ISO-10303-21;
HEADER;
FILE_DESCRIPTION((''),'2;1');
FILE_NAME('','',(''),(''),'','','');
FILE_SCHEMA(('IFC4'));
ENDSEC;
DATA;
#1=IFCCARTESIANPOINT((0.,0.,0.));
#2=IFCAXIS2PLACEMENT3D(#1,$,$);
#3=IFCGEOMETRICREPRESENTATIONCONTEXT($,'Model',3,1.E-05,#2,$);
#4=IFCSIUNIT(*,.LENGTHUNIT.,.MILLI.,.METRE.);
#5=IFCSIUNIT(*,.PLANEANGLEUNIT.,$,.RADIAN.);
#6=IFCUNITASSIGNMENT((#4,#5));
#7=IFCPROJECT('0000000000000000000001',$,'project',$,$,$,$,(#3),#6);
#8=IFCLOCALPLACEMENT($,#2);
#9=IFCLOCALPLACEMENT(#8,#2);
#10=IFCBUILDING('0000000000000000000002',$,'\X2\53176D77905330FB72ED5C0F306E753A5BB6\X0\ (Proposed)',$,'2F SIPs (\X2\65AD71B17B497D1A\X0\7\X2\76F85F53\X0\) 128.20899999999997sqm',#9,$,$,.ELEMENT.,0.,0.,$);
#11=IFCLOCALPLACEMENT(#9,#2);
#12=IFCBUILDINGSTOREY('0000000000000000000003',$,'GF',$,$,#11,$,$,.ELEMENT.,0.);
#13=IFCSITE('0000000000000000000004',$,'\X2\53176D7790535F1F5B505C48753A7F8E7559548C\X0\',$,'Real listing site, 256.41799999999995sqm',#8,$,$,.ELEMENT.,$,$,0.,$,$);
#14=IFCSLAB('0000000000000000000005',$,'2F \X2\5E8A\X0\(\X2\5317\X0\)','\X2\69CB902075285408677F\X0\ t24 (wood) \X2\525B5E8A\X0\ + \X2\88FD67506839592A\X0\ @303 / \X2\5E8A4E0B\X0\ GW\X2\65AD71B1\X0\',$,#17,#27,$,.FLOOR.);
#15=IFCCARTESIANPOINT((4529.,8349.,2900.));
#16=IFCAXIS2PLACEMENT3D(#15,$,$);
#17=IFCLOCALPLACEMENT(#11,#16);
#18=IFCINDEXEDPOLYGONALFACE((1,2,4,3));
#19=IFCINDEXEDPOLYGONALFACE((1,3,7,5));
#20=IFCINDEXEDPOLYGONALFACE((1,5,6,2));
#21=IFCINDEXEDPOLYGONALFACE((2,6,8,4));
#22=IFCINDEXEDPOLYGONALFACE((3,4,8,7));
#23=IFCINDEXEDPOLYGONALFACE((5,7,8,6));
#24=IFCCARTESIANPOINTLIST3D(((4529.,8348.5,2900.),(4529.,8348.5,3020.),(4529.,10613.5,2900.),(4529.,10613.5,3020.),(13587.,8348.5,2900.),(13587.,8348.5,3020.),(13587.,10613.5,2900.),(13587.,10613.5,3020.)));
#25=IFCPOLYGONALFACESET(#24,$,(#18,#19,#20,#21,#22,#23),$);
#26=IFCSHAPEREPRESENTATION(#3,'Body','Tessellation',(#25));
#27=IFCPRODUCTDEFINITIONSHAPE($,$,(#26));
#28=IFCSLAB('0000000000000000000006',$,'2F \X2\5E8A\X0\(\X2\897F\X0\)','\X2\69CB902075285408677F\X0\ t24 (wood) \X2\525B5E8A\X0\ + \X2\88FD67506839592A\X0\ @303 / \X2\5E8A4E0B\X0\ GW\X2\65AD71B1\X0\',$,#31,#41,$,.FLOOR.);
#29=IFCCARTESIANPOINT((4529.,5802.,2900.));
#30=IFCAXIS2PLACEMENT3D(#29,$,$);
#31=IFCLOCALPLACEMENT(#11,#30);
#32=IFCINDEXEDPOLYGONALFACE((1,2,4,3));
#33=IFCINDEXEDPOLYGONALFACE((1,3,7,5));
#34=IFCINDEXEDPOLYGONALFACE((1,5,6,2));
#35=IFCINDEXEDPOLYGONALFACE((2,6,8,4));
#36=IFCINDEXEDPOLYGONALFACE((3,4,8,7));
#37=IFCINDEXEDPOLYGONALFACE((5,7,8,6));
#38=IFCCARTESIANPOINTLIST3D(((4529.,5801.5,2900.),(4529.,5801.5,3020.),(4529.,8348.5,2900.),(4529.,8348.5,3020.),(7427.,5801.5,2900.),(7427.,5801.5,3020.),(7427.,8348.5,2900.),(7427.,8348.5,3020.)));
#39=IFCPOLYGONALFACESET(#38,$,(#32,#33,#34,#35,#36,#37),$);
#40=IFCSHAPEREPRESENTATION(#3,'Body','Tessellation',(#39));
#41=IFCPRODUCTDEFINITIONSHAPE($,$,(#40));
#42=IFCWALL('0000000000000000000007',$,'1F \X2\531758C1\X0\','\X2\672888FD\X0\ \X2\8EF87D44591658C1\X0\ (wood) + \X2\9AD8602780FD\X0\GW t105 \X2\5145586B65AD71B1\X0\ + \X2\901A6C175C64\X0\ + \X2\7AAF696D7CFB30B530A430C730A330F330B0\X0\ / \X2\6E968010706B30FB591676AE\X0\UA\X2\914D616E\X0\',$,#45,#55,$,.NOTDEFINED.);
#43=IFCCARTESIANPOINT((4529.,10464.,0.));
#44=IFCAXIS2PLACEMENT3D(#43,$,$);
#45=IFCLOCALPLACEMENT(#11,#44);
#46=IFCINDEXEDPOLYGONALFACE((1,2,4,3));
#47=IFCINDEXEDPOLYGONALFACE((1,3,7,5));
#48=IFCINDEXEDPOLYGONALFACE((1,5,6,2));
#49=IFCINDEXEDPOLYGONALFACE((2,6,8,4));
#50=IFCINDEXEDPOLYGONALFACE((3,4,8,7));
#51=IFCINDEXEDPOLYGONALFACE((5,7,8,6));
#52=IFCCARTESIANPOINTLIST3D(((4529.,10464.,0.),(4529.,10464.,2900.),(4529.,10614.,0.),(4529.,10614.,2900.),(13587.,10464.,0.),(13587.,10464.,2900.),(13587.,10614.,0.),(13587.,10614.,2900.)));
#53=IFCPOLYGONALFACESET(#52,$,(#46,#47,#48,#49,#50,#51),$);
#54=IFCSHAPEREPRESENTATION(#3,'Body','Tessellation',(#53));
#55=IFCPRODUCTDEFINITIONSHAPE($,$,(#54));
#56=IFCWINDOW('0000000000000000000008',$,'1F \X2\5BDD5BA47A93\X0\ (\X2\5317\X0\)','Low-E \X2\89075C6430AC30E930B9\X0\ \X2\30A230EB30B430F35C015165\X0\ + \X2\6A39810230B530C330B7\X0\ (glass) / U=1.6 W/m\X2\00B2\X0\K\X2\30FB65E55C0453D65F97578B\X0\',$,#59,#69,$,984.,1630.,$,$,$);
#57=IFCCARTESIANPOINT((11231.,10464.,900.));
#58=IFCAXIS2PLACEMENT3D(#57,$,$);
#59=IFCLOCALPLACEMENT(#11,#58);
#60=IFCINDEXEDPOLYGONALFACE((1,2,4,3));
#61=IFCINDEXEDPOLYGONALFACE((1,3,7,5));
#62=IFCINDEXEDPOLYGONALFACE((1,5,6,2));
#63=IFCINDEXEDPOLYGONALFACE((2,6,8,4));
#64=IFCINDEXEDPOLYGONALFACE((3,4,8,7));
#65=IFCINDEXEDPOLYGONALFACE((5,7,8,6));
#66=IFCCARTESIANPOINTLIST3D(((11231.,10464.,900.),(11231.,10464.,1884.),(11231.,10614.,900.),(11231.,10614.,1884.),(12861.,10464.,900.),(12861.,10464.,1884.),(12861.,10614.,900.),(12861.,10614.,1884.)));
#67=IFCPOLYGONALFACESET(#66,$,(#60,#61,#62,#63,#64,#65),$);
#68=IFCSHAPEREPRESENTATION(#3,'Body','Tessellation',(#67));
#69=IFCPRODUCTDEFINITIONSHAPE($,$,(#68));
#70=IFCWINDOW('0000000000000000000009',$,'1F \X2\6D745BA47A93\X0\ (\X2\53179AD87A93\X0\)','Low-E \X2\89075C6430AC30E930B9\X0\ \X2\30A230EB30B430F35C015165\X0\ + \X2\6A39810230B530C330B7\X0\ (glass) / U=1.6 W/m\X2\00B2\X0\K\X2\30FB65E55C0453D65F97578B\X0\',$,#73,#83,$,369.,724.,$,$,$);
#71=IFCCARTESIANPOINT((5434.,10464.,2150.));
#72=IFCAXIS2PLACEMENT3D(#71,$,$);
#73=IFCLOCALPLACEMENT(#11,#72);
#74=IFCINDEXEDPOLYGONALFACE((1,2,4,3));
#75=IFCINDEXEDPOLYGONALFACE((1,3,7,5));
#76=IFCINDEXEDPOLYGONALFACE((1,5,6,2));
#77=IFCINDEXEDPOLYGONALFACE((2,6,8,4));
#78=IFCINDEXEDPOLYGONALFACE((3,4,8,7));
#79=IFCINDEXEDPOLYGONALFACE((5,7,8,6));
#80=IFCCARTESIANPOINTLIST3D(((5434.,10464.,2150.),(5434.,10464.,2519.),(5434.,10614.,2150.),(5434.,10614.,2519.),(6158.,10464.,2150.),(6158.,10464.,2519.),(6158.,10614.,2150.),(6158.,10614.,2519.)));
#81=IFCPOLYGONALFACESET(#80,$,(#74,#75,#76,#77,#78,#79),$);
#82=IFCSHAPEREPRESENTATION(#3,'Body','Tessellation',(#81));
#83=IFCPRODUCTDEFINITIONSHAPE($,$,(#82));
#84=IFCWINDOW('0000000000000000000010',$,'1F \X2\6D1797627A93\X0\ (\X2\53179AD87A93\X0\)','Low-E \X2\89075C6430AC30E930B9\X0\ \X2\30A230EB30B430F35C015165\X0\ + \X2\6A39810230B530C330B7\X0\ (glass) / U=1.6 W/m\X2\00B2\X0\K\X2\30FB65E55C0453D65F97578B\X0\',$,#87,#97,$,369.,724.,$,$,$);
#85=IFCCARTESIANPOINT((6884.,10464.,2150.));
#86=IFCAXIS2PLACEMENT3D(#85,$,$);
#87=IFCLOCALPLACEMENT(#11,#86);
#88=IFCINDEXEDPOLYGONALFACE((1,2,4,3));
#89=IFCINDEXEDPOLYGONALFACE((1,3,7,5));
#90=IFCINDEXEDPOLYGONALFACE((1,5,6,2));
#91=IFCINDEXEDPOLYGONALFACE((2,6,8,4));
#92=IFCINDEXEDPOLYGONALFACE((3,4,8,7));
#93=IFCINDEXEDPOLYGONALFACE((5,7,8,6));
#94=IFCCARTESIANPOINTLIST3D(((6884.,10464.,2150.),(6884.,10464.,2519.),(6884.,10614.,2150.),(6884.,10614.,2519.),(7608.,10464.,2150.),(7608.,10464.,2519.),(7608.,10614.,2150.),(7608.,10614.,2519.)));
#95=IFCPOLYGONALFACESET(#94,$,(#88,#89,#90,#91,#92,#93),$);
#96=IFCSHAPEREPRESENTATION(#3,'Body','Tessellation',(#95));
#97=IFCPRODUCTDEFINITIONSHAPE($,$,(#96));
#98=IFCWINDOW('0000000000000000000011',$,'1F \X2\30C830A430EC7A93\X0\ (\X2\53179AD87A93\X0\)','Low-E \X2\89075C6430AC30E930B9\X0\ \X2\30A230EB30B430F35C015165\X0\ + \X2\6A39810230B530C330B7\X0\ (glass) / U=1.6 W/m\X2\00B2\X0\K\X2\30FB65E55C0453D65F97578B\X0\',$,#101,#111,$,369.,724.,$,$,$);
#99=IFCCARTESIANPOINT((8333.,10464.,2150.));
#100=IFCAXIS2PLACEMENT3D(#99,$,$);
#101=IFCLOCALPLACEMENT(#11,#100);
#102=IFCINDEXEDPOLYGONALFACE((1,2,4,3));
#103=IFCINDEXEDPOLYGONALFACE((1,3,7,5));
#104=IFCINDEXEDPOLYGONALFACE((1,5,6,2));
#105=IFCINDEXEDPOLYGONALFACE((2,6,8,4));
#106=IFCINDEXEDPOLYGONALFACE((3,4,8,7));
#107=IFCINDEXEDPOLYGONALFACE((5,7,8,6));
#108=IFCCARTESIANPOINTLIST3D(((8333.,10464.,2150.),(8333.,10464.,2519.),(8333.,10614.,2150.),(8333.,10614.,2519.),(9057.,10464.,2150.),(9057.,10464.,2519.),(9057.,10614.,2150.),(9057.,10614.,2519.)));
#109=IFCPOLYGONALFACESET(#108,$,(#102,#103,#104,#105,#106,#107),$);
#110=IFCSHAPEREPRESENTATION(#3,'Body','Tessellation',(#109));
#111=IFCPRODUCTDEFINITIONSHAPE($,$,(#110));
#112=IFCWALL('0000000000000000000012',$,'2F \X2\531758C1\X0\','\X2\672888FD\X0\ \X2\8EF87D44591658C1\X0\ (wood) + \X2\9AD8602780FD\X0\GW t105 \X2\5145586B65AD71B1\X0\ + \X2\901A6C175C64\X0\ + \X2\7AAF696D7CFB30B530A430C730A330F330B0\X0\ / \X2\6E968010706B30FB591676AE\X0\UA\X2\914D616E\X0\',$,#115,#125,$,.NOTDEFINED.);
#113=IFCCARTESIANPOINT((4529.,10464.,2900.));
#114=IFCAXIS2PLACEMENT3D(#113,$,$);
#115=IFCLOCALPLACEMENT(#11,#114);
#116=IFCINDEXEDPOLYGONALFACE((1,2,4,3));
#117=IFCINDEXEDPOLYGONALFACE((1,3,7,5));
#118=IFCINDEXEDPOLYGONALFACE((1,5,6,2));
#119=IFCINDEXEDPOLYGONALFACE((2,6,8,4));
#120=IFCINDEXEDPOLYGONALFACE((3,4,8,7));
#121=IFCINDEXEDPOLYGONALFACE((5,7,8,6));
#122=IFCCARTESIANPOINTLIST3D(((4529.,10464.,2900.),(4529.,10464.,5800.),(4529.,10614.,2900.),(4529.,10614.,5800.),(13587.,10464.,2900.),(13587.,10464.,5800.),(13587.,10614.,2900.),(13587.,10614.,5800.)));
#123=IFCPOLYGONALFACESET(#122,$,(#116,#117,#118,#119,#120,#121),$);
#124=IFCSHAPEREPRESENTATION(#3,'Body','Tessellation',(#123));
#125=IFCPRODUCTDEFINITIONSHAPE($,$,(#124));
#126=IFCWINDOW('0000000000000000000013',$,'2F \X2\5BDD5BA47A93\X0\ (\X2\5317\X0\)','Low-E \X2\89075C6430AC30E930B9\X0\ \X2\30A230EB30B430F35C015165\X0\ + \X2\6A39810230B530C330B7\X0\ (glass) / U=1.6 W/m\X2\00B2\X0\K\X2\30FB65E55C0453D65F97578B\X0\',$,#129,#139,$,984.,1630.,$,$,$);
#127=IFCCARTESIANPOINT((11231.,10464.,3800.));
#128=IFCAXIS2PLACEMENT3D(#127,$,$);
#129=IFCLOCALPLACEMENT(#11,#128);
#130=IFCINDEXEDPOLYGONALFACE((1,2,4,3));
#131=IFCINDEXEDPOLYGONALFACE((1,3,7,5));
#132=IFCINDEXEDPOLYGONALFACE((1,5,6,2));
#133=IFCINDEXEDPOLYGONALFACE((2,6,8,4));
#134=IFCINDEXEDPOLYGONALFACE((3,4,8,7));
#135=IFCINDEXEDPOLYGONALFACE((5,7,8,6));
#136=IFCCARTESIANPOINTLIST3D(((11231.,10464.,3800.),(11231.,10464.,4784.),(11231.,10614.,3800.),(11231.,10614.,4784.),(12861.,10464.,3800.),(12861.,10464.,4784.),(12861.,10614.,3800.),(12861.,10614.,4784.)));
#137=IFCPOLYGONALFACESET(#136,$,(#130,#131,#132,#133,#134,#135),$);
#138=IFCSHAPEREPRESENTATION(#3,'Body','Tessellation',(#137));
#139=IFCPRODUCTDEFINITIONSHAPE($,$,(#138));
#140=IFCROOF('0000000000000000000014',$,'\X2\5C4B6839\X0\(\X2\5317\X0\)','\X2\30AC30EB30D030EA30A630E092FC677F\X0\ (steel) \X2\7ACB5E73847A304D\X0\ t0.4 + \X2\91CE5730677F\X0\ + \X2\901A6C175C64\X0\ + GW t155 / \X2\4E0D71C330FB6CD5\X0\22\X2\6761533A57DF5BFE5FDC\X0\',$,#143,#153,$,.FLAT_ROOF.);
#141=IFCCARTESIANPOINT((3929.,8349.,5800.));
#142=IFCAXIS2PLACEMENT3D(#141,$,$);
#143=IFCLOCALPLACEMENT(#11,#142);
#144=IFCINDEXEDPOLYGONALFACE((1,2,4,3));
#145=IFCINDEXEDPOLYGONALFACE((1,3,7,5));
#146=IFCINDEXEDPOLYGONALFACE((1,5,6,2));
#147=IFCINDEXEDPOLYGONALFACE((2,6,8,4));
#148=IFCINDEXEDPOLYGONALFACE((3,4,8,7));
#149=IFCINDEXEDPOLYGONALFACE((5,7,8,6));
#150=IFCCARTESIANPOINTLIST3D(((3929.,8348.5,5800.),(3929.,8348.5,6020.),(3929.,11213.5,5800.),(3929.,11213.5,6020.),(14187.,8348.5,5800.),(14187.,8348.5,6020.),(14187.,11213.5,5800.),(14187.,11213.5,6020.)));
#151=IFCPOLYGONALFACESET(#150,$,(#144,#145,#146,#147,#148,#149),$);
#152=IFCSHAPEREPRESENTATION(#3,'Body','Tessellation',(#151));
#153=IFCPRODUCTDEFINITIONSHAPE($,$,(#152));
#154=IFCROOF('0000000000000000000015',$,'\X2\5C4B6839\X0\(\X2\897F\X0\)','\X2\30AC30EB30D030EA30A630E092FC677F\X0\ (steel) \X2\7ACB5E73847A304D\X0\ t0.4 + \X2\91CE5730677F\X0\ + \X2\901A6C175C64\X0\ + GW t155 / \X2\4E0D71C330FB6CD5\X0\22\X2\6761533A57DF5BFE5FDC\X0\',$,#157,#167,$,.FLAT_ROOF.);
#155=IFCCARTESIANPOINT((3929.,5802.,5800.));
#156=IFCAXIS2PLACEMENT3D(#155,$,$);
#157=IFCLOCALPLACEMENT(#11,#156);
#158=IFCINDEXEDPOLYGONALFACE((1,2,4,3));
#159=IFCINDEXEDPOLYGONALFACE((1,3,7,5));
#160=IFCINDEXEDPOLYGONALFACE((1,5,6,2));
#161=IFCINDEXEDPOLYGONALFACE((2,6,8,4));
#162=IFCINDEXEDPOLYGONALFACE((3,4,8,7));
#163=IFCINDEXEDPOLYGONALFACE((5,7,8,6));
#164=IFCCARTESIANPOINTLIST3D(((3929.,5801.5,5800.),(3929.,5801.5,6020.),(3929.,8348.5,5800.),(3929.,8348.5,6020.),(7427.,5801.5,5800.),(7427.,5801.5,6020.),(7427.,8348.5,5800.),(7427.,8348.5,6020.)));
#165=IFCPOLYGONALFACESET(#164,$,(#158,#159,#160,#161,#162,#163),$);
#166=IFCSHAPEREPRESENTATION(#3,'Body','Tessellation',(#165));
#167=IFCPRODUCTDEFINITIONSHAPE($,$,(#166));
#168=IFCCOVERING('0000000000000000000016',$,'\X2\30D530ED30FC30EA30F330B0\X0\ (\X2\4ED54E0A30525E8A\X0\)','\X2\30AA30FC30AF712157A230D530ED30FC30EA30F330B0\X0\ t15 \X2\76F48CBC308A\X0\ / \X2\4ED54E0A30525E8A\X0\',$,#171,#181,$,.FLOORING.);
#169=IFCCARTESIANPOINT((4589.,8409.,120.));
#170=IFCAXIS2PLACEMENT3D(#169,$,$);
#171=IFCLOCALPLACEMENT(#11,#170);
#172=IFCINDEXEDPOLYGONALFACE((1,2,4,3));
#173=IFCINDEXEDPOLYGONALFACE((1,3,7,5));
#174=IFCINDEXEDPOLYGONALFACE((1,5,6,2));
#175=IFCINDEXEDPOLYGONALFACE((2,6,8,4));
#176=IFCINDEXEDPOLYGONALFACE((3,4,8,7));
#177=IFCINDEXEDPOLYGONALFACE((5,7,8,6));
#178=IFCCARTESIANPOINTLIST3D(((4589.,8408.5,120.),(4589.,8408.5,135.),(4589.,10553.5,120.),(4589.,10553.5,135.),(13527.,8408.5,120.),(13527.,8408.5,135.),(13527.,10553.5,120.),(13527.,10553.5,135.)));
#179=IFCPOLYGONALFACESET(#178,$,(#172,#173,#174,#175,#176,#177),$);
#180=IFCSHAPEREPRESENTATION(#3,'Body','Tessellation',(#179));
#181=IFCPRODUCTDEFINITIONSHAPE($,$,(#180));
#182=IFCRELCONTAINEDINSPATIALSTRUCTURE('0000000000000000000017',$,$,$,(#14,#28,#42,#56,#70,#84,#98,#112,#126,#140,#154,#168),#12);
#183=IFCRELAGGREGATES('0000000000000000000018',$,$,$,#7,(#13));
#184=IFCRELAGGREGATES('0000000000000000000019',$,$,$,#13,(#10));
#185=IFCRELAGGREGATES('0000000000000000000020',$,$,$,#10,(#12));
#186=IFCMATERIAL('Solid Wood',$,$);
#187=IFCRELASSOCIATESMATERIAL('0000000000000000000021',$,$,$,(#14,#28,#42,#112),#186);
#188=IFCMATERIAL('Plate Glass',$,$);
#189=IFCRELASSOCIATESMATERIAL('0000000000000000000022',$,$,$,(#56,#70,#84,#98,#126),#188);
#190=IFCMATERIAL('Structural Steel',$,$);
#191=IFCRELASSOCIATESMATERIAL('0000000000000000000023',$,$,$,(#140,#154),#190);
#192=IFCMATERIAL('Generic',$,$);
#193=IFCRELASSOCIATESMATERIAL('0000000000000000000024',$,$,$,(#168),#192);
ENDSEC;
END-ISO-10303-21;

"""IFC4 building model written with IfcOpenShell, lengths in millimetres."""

from ifc_helpers import new_model, si_unit, frame, frame_2d, origin, place, context, project, spatial, rectangle, extrude, material, element, fill, save


model = new_model("IFC4")

# Units and contexts
model_context = context("Model", 3, precision=1e-05, world=origin())
ifc_project = project(units=[si_unit("LENGTHUNIT", "METRE", prefix="MILLI"), si_unit("PLANEANGLEUNIT", "RADIAN")], contexts=[model_context])

# Site, building, storey
site_placement = place(None, origin())
site = spatial("IfcSite", under=ifc_project, at=site_placement, Name="北海道弟子屈町美留和", ObjectType="Real listing site, 256.41799999999995sqm", CompositionType="ELEMENT", RefElevation=0.0)
building_placement = place(site_placement, origin())
building = spatial("IfcBuilding", under=site, at=building_placement, Name="北海道・狭小の町家 (Proposed)", ObjectType="2F SIPs (断熱等級7相当) 128.20899999999997sqm", CompositionType="ELEMENT", ElevationOfRefHeight=0.0, ElevationOfTerrain=0.0)
storey_placement = place(building_placement, origin())
storey = spatial("IfcBuildingStorey", under=building, at=storey_placement, Name="GF", CompositionType="ELEMENT", Elevation=0.0)

# Slabs
ifc_material_1 = material(Name="Solid Wood")
slab_1_placement = place(storey_placement, frame((4529.0, 8349.0, 2900.0)))
element("IfcSlab", 1, at=slab_1_placement, inside=storey, material=ifc_material_1, Name="2F 床(北)", Description="構造用合板 t24 (wood) 剛床 + 製材根太 @303 / 床下 GW断熱", PredefinedType="FLOOR", context=model_context, shape_type="SweptSolid", body=[
    extrude(rectangle(XDim=9058.0, YDim=2265.0, at=frame_2d((4529.0, 1132.0))), frame((4529.0, 8349.0, 2900.0)), (0.0, 0.0, 1.0), 120.0),
])
slab_2_placement = place(storey_placement, frame((4529.0, 5802.0, 2900.0)))
element("IfcSlab", 2, at=slab_2_placement, inside=storey, material=ifc_material_1, Name="2F 床(西)", Description="構造用合板 t24 (wood) 剛床 + 製材根太 @303 / 床下 GW断熱", PredefinedType="FLOOR", context=model_context, shape_type="SweptSolid", body=[
    extrude(rectangle(XDim=2898.0, YDim=2547.0, at=frame_2d((1449.0, 1273.0))), frame((4529.0, 5802.0, 2900.0)), (0.0, 0.0, 1.0), 120.0),
])

# Wall, openings, windows
wall_1_placement = place(storey_placement, frame((4529.0, 10464.0, 0.0)))
wall_1 = element("IfcWall", 3, at=wall_1_placement, inside=storey, material=ifc_material_1, Name="1F 北壁", Description="木製 軸組外壁 (wood) + 高性能GW t105 充填断熱 + 通気層 + 窯業系サイディング / 準耐火・外皮UA配慮", PredefinedType="NOTDEFINED", context=model_context, shape_type="SweptSolid", body=[
    extrude(rectangle(XDim=9058.0, YDim=150.0, at=frame_2d((4529.0, 75.0))), frame((4529.0, 10464.0, 0.0)), (0.0, 0.0, 1.0), 2900.0),
])
opening_1_placement = place(storey_placement, frame((11231.0, 10464.0, 900.0)))
opening_1 = element("IfcOpeningElement", 4, at=opening_1_placement, cuts=wall_1, PredefinedType="NOTDEFINED", context=model_context, shape_type="SweptSolid", body=[
    extrude(rectangle(XDim=1630.0, YDim=150.0, at=frame_2d((815.0, 75.0))), frame((11231.0, 10464.0, 900.0)), (0.0, 0.0, 1.0), 984.0),
])
opening_2_placement = place(storey_placement, frame((5434.0, 10464.0, 2150.0)))
opening_2 = element("IfcOpeningElement", 5, at=opening_2_placement, cuts=wall_1, PredefinedType="NOTDEFINED", context=model_context, shape_type="SweptSolid", body=[
    extrude(rectangle(XDim=724.0, YDim=150.0, at=frame_2d((362.0, 75.0))), frame((5434.0, 10464.0, 2150.0)), (0.0, 0.0, 1.0), 369.0),
])
opening_3_placement = place(storey_placement, frame((6884.0, 10464.0, 2150.0)))
opening_3 = element("IfcOpeningElement", 6, at=opening_3_placement, cuts=wall_1, PredefinedType="NOTDEFINED", context=model_context, shape_type="SweptSolid", body=[
    extrude(rectangle(XDim=724.0, YDim=150.0, at=frame_2d((362.0, 75.0))), frame((6884.0, 10464.0, 2150.0)), (0.0, 0.0, 1.0), 369.0),
])
opening_4_placement = place(storey_placement, frame((8333.0, 10464.0, 2150.0)))
opening_4 = element("IfcOpeningElement", 7, at=opening_4_placement, cuts=wall_1, PredefinedType="NOTDEFINED", context=model_context, shape_type="SweptSolid", body=[
    extrude(rectangle(XDim=724.0, YDim=150.0, at=frame_2d((362.0, 75.0))), frame((8333.0, 10464.0, 2150.0)), (0.0, 0.0, 1.0), 369.0),
])
ifc_material_2 = material(Name="Plate Glass")
window_1_placement = place(storey_placement, frame((11231.0, 10464.0, 900.0)))
window_1 = element("IfcWindow", 8, at=window_1_placement, inside=storey, material=ifc_material_2, Name="1F 寝室窓 (北)", Description="Low-E 複層ガラス アルゴン封入 + 樹脂サッシ (glass) / U=1.6 W/m²K・日射取得型", OverallHeight=984.0, OverallWidth=1630.0, context=model_context, shape_type="SweptSolid", body=[
    extrude(rectangle(XDim=1630.0, YDim=150.0, at=frame_2d((815.0, 75.0))), frame((11231.0, 10464.0, 900.0)), (0.0, 0.0, 1.0), 984.0),
])
fill(opening_1, window_1)
window_2_placement = place(storey_placement, frame((5434.0, 10464.0, 2150.0)))
window_2 = element("IfcWindow", 9, at=window_2_placement, inside=storey, material=ifc_material_2, Name="1F 浴室窓 (北高窓)", Description="Low-E 複層ガラス アルゴン封入 + 樹脂サッシ (glass) / U=1.6 W/m²K・日射取得型", OverallHeight=369.0, OverallWidth=724.0, context=model_context, shape_type="SweptSolid", body=[
    extrude(rectangle(XDim=724.0, YDim=150.0, at=frame_2d((362.0, 75.0))), frame((5434.0, 10464.0, 2150.0)), (0.0, 0.0, 1.0), 369.0),
])
fill(opening_2, window_2)
window_3_placement = place(storey_placement, frame((6884.0, 10464.0, 2150.0)))
window_3 = element("IfcWindow", 10, at=window_3_placement, inside=storey, material=ifc_material_2, Name="1F 洗面窓 (北高窓)", Description="Low-E 複層ガラス アルゴン封入 + 樹脂サッシ (glass) / U=1.6 W/m²K・日射取得型", OverallHeight=369.0, OverallWidth=724.0, context=model_context, shape_type="SweptSolid", body=[
    extrude(rectangle(XDim=724.0, YDim=150.0, at=frame_2d((362.0, 75.0))), frame((6884.0, 10464.0, 2150.0)), (0.0, 0.0, 1.0), 369.0),
])
fill(opening_3, window_3)
window_4_placement = place(storey_placement, frame((8333.0, 10464.0, 2150.0)))
window_4 = element("IfcWindow", 11, at=window_4_placement, inside=storey, material=ifc_material_2, Name="1F トイレ窓 (北高窓)", Description="Low-E 複層ガラス アルゴン封入 + 樹脂サッシ (glass) / U=1.6 W/m²K・日射取得型", OverallHeight=369.0, OverallWidth=724.0, context=model_context, shape_type="SweptSolid", body=[
    extrude(rectangle(XDim=724.0, YDim=150.0, at=frame_2d((362.0, 75.0))), frame((8333.0, 10464.0, 2150.0)), (0.0, 0.0, 1.0), 369.0),
])
fill(opening_4, window_4)

# Wall, opening, window
wall_2_placement = place(storey_placement, frame((4529.0, 10464.0, 2900.0)))
wall_2 = element("IfcWall", 12, at=wall_2_placement, inside=storey, material=ifc_material_1, Name="2F 北壁", Description="木製 軸組外壁 (wood) + 高性能GW t105 充填断熱 + 通気層 + 窯業系サイディング / 準耐火・外皮UA配慮", PredefinedType="NOTDEFINED", context=model_context, shape_type="SweptSolid", body=[
    extrude(rectangle(XDim=9058.0, YDim=150.0, at=frame_2d((4529.0, 75.0))), frame((4529.0, 10464.0, 2900.0)), (0.0, 0.0, 1.0), 2900.0),
])
opening_5_placement = place(storey_placement, frame((11231.0, 10464.0, 3800.0)))
opening_5 = element("IfcOpeningElement", 13, at=opening_5_placement, cuts=wall_2, PredefinedType="NOTDEFINED", context=model_context, shape_type="SweptSolid", body=[
    extrude(rectangle(XDim=1630.0, YDim=150.0, at=frame_2d((815.0, 75.0))), frame((11231.0, 10464.0, 3800.0)), (0.0, 0.0, 1.0), 984.0),
])
window_5_placement = place(storey_placement, frame((11231.0, 10464.0, 3800.0)))
window_5 = element("IfcWindow", 14, at=window_5_placement, inside=storey, material=ifc_material_2, Name="2F 寝室窓 (北)", Description="Low-E 複層ガラス アルゴン封入 + 樹脂サッシ (glass) / U=1.6 W/m²K・日射取得型", OverallHeight=984.0, OverallWidth=1630.0, context=model_context, shape_type="SweptSolid", body=[
    extrude(rectangle(XDim=1630.0, YDim=150.0, at=frame_2d((815.0, 75.0))), frame((11231.0, 10464.0, 3800.0)), (0.0, 0.0, 1.0), 984.0),
])
fill(opening_5, window_5)

# Roofs
ifc_material_3 = material(Name="Structural Steel")
for number, where, name in (
    (15, (3929.0, 8349.0, 5800.0), "屋根(北)"),
):
    element("IfcRoof", number, at=place(storey_placement, frame(where)), inside=storey, material=ifc_material_3, Name=name, Description="ガルバリウム鋼板 (steel) 立平葺き t0.4 + 野地板 + 通気層 + GW t155 / 不燃・法22条区域対応", PredefinedType="FLAT_ROOF", context=model_context, shape_type="SweptSolid", body=[
        extrude(rectangle(XDim=10258.0, YDim=2865.0, at=frame_2d((5129.0, 1432.0))), frame((3929.0, 8349.0, 5800.0)), (0.0, 0.0, 1.0), 220.0),
    ])
roof_placement = place(storey_placement, frame((3929.0, 5802.0, 5800.0)))
element("IfcRoof", 16, at=roof_placement, inside=storey, material=ifc_material_3, Name="屋根(西)", Description="ガルバリウム鋼板 (steel) 立平葺き t0.4 + 野地板 + 通気層 + GW t155 / 不燃・法22条区域対応", PredefinedType="FLAT_ROOF", context=model_context, shape_type="SweptSolid", body=[
    extrude(rectangle(XDim=3498.0, YDim=2547.0, at=frame_2d((1749.0, 1273.0))), frame((3929.0, 5802.0, 5800.0)), (0.0, 0.0, 1.0), 220.0),
])

# Covering
ifc_material_4 = material(Name="Generic")
covering_1_placement = place(storey_placement, frame((4589.0, 8409.0, 120.0)))
element("IfcCovering", 17, at=covering_1_placement, inside=storey, material=ifc_material_4, Name="フローリング (仕上げ床)", Description="オーク無垢フローリング t15 直貼り / 仕上げ床", PredefinedType="FLOORING", context=model_context, shape_type="SweptSolid", body=[
    extrude(rectangle(XDim=8938.0, YDim=2145.0, at=frame_2d((4469.0, 1072.0))), frame((4589.0, 8409.0, 120.0)), (0.0, 0.0, 1.0), 15.0),
])

save(model, "model.ifc")
